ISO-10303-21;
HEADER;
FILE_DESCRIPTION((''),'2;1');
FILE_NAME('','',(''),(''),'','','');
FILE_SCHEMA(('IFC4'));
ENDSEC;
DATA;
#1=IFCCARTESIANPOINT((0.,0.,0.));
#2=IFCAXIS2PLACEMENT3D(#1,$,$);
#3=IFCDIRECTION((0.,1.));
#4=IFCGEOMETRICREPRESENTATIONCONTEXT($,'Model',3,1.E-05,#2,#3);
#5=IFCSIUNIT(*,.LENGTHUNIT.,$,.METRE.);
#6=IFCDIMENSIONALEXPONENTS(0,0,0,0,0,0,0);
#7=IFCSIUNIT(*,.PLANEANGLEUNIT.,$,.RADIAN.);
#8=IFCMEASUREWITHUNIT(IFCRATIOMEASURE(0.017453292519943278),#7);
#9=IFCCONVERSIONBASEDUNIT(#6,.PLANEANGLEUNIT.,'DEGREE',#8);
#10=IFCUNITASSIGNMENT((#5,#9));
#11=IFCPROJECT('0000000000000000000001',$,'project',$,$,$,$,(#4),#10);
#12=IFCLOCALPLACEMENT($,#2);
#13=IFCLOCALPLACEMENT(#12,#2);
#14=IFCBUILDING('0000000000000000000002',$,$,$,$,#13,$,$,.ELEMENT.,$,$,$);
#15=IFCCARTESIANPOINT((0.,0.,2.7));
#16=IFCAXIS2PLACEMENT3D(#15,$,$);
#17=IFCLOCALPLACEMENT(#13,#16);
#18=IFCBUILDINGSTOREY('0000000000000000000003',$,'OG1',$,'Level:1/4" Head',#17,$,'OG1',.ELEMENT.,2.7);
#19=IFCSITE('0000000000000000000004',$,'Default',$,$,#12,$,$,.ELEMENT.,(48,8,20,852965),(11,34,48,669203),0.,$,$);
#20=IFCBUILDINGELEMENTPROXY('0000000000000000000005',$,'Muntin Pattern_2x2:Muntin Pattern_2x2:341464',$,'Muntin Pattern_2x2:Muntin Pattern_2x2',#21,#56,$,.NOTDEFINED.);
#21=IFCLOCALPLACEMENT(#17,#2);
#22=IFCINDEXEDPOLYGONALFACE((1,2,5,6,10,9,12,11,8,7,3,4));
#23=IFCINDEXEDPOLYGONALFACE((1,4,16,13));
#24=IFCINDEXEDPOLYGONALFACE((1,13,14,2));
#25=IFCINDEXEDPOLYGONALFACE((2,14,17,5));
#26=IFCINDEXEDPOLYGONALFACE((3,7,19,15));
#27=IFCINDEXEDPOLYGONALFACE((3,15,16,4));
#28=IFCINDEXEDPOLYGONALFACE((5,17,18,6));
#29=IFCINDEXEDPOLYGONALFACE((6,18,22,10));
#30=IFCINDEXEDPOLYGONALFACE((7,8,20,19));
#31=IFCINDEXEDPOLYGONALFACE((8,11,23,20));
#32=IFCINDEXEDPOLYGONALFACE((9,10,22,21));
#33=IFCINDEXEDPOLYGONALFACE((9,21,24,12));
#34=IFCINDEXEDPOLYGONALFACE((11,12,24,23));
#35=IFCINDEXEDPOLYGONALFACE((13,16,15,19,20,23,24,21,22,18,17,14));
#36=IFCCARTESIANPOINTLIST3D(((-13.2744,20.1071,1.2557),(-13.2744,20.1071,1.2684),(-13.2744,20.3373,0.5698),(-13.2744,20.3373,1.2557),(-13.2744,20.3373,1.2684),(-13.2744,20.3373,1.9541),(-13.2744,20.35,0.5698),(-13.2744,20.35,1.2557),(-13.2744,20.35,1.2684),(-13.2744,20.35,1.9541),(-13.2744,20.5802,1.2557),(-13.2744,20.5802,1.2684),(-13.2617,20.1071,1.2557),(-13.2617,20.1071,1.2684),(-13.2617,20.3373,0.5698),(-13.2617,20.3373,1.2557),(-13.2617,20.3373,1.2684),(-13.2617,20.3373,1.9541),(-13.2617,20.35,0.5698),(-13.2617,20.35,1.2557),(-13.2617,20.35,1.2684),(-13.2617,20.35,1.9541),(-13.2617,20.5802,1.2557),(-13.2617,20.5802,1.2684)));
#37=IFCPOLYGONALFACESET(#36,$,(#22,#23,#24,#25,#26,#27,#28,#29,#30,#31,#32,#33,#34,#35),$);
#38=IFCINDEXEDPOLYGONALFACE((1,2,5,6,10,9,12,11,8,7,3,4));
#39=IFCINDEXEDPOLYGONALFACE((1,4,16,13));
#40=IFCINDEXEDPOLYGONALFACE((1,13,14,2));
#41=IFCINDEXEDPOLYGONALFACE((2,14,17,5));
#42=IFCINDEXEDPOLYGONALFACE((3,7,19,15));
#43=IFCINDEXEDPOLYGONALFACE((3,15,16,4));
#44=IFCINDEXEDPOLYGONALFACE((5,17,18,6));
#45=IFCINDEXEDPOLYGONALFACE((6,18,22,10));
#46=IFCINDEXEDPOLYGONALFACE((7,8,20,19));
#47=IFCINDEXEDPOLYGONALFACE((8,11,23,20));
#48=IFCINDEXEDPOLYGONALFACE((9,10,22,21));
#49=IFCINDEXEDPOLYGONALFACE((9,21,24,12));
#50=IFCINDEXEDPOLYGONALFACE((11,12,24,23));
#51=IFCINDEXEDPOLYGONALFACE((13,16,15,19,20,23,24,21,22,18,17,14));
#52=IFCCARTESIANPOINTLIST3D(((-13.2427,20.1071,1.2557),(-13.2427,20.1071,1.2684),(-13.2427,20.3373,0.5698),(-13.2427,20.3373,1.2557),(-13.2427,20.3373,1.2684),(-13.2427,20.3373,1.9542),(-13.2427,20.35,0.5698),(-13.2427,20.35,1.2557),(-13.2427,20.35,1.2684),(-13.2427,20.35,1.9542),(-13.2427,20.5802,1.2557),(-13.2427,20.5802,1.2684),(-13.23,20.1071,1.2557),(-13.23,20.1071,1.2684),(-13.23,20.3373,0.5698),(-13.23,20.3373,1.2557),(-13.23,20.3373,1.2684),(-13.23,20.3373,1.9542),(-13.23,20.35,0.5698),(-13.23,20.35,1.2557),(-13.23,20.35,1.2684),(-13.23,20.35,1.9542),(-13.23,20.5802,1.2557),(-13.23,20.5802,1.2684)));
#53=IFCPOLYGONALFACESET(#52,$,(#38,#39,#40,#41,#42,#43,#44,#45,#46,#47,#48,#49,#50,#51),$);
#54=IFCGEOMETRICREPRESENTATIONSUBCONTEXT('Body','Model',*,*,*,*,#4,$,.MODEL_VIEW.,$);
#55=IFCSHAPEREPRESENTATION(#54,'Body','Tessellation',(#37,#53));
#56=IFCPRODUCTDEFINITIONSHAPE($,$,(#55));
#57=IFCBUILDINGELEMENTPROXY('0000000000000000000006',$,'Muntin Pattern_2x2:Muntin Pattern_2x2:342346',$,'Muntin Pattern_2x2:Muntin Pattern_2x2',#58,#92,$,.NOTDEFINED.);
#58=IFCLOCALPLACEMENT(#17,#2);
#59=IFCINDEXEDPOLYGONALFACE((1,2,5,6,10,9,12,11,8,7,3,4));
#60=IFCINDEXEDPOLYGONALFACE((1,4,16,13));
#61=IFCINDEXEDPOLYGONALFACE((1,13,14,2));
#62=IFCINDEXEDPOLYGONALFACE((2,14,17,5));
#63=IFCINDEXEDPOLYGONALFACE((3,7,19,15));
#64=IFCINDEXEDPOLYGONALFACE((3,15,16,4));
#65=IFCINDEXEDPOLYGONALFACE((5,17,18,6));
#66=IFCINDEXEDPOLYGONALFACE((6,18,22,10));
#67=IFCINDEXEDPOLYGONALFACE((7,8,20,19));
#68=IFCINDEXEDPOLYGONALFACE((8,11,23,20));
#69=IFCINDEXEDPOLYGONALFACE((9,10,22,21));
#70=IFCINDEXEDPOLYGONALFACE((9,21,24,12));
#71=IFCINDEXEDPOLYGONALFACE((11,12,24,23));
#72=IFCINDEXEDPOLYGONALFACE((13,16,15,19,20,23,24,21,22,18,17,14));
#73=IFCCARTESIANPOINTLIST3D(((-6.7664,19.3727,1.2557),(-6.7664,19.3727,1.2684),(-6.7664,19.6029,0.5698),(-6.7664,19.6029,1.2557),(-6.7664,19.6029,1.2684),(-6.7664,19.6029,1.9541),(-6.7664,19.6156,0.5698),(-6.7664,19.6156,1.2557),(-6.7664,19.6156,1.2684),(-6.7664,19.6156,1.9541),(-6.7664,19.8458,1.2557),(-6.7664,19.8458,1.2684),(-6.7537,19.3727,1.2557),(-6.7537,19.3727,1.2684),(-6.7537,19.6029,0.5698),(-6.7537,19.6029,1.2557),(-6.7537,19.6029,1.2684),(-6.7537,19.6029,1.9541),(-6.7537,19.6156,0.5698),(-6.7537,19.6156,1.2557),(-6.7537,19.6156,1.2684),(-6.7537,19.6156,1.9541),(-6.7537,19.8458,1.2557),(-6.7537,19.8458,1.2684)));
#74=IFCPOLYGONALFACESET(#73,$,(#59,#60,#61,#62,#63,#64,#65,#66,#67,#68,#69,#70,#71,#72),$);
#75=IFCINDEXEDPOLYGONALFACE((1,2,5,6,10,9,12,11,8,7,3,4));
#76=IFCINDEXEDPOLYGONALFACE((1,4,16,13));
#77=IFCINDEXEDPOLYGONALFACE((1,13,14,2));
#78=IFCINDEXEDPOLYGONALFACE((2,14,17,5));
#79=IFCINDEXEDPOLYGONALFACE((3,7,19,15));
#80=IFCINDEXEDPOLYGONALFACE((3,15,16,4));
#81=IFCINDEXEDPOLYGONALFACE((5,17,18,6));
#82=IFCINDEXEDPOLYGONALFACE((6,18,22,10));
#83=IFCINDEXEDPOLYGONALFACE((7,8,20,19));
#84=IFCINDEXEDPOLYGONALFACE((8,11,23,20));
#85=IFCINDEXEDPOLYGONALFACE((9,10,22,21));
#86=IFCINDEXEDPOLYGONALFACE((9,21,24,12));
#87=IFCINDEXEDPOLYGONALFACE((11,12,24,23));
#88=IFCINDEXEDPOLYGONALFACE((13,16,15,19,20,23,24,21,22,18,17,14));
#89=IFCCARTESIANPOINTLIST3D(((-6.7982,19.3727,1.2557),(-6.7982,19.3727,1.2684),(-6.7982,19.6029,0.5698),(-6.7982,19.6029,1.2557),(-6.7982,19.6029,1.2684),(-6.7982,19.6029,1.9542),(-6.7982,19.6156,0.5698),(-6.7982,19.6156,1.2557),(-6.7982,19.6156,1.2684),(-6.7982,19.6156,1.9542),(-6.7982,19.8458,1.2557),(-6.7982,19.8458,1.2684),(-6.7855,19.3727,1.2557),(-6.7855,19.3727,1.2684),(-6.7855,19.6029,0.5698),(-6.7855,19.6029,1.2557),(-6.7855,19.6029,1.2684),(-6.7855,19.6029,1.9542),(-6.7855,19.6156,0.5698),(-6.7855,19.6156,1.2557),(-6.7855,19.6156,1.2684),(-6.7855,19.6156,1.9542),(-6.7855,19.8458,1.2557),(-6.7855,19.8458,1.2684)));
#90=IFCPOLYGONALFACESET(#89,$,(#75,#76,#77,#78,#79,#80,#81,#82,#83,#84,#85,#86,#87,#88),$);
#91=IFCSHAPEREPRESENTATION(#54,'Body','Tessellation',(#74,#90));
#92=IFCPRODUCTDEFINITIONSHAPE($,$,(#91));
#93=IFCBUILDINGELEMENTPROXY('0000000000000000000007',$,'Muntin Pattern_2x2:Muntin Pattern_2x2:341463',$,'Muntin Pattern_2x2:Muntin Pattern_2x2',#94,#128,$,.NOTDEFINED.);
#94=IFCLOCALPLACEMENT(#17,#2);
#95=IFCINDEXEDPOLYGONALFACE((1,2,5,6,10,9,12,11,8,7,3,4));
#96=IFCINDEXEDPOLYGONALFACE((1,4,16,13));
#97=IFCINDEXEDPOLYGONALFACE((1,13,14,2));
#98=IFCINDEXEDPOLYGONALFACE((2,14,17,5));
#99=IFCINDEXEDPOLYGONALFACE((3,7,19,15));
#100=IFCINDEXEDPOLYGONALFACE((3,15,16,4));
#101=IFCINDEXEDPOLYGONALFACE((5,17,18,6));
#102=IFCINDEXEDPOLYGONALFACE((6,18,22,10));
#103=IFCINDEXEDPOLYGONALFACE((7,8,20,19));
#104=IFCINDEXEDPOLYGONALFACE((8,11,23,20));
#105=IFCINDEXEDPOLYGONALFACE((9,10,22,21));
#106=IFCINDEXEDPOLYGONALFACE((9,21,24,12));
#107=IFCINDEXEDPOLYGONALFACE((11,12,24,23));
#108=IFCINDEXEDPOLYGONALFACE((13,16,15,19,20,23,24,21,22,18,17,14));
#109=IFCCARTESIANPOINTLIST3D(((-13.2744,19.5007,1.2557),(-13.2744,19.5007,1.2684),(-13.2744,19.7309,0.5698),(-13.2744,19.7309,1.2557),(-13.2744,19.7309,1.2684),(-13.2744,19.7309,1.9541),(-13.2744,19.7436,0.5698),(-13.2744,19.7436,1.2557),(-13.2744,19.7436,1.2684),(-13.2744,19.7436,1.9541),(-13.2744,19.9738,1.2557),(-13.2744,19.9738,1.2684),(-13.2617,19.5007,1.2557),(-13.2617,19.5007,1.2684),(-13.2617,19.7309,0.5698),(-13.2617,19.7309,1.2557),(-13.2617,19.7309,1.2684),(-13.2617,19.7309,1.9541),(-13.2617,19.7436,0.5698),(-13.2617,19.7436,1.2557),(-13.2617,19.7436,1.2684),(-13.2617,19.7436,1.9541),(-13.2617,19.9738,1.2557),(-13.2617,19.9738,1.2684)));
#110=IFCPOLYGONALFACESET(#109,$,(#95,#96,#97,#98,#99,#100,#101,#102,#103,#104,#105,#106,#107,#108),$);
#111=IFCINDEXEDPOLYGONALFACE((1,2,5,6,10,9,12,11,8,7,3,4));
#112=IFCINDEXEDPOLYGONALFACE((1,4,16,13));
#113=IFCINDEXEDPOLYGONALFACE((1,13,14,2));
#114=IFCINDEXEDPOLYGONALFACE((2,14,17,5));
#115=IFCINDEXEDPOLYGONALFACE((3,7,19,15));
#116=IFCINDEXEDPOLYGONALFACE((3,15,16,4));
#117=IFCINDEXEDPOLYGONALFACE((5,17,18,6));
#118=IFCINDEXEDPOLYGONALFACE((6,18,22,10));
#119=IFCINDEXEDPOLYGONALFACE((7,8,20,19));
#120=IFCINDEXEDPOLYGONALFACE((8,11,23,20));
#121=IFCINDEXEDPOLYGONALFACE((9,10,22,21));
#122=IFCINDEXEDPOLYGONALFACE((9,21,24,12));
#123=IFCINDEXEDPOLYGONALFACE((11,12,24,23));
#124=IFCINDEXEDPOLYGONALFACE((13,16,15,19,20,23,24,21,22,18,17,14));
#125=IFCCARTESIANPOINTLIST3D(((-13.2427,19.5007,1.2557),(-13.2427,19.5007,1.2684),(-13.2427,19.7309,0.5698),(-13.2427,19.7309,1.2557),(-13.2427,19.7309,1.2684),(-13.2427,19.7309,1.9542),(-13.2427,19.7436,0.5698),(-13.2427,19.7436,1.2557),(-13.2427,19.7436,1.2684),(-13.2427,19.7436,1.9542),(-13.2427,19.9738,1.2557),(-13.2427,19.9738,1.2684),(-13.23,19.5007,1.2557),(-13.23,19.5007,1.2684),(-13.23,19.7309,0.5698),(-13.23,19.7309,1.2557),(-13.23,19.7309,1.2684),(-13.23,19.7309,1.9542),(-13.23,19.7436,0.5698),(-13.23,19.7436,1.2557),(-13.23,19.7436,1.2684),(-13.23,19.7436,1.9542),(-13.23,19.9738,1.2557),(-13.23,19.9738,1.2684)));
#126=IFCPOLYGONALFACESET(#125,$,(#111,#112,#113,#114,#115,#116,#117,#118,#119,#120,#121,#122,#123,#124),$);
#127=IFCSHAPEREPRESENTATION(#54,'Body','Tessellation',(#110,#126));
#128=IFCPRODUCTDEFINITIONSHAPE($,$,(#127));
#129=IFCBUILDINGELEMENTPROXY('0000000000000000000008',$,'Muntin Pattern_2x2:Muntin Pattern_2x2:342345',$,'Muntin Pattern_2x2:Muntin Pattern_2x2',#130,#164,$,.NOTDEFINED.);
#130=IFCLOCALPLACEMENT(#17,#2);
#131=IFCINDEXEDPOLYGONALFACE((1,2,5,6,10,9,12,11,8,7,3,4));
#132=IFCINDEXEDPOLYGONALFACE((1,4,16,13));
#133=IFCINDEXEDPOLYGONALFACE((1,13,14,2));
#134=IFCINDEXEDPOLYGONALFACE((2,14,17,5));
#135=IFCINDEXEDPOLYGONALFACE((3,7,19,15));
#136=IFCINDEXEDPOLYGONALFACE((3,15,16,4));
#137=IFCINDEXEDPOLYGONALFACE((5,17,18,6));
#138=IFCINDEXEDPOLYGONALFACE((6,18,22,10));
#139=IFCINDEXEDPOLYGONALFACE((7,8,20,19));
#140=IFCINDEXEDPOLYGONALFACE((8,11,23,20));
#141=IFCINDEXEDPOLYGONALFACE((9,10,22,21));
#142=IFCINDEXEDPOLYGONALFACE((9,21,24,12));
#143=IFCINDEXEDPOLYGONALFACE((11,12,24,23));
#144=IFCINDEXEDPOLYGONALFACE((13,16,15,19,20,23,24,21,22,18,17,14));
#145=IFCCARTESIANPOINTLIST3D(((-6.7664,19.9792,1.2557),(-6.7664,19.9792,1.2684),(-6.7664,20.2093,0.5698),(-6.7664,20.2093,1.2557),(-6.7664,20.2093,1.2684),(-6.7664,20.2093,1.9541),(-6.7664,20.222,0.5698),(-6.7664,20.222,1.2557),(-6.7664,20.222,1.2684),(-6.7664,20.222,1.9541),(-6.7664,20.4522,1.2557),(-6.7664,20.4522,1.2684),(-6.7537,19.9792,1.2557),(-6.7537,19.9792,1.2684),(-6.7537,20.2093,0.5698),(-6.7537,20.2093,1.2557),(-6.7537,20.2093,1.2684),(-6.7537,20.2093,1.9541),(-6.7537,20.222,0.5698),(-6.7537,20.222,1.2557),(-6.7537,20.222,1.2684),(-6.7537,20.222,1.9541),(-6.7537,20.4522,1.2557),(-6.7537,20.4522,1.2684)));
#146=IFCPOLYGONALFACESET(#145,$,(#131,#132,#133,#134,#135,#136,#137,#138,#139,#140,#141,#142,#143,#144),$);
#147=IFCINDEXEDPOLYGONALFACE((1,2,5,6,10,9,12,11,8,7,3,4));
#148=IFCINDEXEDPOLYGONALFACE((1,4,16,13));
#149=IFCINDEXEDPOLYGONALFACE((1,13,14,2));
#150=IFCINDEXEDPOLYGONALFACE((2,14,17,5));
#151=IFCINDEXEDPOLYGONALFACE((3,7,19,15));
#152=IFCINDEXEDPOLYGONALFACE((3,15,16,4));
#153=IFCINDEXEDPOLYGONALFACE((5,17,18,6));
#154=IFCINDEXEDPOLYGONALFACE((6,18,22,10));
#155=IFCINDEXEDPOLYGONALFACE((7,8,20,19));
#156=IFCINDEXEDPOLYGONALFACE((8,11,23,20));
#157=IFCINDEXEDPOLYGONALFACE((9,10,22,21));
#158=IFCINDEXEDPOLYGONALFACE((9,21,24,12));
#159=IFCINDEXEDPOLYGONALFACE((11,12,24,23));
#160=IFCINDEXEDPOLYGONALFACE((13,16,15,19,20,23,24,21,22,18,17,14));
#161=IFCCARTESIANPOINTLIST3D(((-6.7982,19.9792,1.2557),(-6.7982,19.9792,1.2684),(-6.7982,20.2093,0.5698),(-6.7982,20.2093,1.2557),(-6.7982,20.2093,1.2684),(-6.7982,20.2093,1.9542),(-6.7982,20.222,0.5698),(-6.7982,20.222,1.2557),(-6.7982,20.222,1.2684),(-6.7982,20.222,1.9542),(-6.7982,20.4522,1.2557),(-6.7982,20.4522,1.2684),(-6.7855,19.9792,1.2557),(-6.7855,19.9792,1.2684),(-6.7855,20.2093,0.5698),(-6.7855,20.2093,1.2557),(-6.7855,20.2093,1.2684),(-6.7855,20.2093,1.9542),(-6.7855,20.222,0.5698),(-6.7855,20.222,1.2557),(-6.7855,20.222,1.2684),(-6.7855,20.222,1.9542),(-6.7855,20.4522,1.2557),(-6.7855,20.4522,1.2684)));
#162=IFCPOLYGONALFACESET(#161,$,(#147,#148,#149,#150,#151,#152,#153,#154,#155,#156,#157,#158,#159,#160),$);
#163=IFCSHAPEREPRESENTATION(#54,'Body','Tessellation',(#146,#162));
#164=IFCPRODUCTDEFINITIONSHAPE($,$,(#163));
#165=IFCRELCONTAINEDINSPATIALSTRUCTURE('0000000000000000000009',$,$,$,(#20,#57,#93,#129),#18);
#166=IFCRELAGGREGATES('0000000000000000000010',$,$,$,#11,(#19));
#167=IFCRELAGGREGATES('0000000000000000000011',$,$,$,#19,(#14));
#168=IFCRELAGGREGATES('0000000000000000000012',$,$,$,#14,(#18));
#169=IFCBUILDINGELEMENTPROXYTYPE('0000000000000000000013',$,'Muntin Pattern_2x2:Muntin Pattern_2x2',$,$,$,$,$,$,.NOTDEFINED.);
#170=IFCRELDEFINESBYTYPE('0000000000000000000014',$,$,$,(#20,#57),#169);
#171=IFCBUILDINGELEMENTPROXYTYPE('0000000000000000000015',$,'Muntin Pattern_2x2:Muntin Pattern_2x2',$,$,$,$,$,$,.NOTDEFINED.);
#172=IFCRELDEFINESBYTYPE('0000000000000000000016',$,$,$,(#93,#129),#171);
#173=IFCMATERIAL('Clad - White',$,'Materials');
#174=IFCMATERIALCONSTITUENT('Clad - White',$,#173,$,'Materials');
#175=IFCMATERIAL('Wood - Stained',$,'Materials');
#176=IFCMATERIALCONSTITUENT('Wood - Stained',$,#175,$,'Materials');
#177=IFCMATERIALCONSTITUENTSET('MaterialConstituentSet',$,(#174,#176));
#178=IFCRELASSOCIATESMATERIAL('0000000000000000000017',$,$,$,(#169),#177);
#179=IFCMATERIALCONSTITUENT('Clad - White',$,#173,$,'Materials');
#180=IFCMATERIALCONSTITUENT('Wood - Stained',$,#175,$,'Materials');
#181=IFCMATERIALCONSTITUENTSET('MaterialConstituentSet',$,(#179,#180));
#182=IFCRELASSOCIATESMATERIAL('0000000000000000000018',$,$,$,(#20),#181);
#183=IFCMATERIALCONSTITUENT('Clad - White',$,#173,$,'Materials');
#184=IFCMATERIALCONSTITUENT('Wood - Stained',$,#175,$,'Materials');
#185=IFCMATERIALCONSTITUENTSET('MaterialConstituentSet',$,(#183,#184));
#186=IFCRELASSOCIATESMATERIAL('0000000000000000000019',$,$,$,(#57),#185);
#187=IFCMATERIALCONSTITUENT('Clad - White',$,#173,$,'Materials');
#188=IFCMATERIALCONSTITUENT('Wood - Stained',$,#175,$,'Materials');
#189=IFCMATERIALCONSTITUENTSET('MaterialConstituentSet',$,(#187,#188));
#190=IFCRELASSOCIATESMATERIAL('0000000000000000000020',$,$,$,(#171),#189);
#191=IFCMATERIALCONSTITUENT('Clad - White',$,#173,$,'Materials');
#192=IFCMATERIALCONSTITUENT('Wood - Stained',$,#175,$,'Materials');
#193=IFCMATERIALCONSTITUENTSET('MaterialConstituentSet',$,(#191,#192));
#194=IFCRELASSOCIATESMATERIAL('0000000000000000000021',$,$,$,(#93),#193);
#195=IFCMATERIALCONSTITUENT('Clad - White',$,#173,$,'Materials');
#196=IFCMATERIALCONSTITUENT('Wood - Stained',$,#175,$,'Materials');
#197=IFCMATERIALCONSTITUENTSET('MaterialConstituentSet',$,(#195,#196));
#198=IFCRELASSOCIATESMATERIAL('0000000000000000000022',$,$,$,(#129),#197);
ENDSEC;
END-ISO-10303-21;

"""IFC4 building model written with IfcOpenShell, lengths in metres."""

from ifc_helpers import new_model, entity, si_unit, converted_unit, direction, frame, origin, place, context, subcontext, project, spatial, indexed_curve, outline, extrude, source, transform, mapped, material, constituent, constituent_set, type_object, type_shapes, element, save


model = new_model("IFC4")

# Units and contexts
model_context = context("Model", 3, precision=1e-05, world=origin(), true_north=direction((0.0, 1.0)))
body_context = subcontext(model_context, "Body", "Model", "MODEL_VIEW")
ifc_project = project(units=[si_unit("LENGTHUNIT", "METRE"), converted_unit("PLANEANGLEUNIT", "DEGREE", entity("IfcRatioMeasure", 0.017453292519943278), si_unit("PLANEANGLEUNIT", "RADIAN"), dimensions=[0, 0, 0, 0, 0, 0, 0])], contexts=[model_context])

# Site, building, storey
site_placement = place(None, origin())
site = spatial("IfcSite", under=ifc_project, at=site_placement, Name="Default", CompositionType="ELEMENT", RefLatitude=(48, 8, 20, 852965), RefLongitude=(11, 34, 48, 669203), RefElevation=0.0)
building_placement = place(site_placement, origin())
building = spatial("IfcBuilding", under=site, at=building_placement, CompositionType="ELEMENT")
storey_placement = place(building_placement, frame((0.0, 0.0, 2.7)))
storey = spatial("IfcBuildingStorey", under=building, at=storey_placement, Name="OG1", ObjectType="Level:1/4\" Head", LongName="OG1", CompositionType="ELEMENT", Elevation=2.7)

# Building element proxies
ifc_material_1 = material(Name="Clad - White", Category="Materials")
ifc_material_2 = material(Name="Wood - Stained", Category="Materials")
ifc_constituent_1 = constituent(ifc_material_1, Name="Clad - White", Category="Materials")
ifc_constituent_2 = constituent(ifc_material_2, Name="Wood - Stained", Category="Materials")
ifc_constituent_set_1 = constituent_set(constituents=[ifc_constituent_1, ifc_constituent_2], Name="MaterialConstituentSet")
building_element_proxy_type_1 = type_object("IfcBuildingElementProxyType", Name="Muntin Pattern_2x2:Muntin Pattern_2x2", PredefinedType="NOTDEFINED", material=ifc_constituent_set_1)
shared_shape_1 = source(origin(), body_context, "Body", "SweptSolid", [
    extrude(outline(indexed_curve([(0.0064, -0.0064), (0.6921, -0.0064), (0.6921, 0.0063), (0.0064, 0.0063), (0.0064, 0.2365), (-0.0063, 0.2365), (-0.0063, 0.0063), (-0.6922, 0.0063), (-0.6922, -0.0064), (-0.0063, -0.0064), (-0.0063, -0.2365), (0.0064, -0.2365), (0.0064, -0.0064)], self_intersect=False)), frame((0.0, -0.0222, 0.6921), z_axis=(0.0, 1.0, 0.0), x_axis=(0.0, 0.0, 1.0)), (0.0, 0.0, 1.0), 0.0127),
    extrude(outline(indexed_curve([(0.0064, -0.0064), (0.6922, -0.0064), (0.6922, 0.0063), (0.0064, 0.0063), (0.0064, 0.2365), (-0.0063, 0.2365), (-0.0063, 0.0063), (-0.6922, 0.0063), (-0.6922, -0.0064), (-0.0063, -0.0064), (-0.0063, -0.2365), (0.0064, -0.2365), (0.0064, -0.0064)], self_intersect=False)), frame((0.0, 0.0095, 0.6922), z_axis=(0.0, 1.0, 0.0), x_axis=(0.0, 0.0, 1.0)), (0.0, 0.0, 1.0), 0.0127),
])
type_shapes(building_element_proxy_type_1, [shared_shape_1])
ifc_constituent_3 = constituent(ifc_material_1, Name="Clad - White", Category="Materials")
ifc_constituent_4 = constituent(ifc_material_2, Name="Wood - Stained", Category="Materials")
ifc_constituent_set_2 = constituent_set(constituents=[ifc_constituent_3, ifc_constituent_4], Name="MaterialConstituentSet")
proxy_1_placement = place(storey_placement, frame((-13.2522, 20.3437, 0.5699), z_axis=(0.0, 0.0, 1.0), x_axis=(0.0, -1.0, 0.0)))
element("IfcBuildingElementProxy", 1, at=proxy_1_placement, inside=storey, type_object=building_element_proxy_type_1, material=ifc_constituent_set_2, Name="Muntin Pattern_2x2:Muntin Pattern_2x2:341464", ObjectType="Muntin Pattern_2x2:Muntin Pattern_2x2", PredefinedType="NOTDEFINED", context=body_context, shape_type="MappedRepresentation", body=[
    mapped(shared_shape_1, transform((0.0, 0.0, 0.0), scale=1.0)),
])
ifc_constituent_5 = constituent(ifc_material_1, Name="Clad - White", Category="Materials")
ifc_constituent_6 = constituent(ifc_material_2, Name="Wood - Stained", Category="Materials")
ifc_constituent_set_3 = constituent_set(constituents=[ifc_constituent_5, ifc_constituent_6], Name="MaterialConstituentSet")
proxy_2_placement = place(storey_placement, frame((-6.7759, 19.6093, 0.5699), z_axis=(0.0, 0.0, 1.0), x_axis=(0.0, 1.0, 0.0)))
element("IfcBuildingElementProxy", 2, at=proxy_2_placement, inside=storey, type_object=building_element_proxy_type_1, material=ifc_constituent_set_3, Name="Muntin Pattern_2x2:Muntin Pattern_2x2:342346", ObjectType="Muntin Pattern_2x2:Muntin Pattern_2x2", PredefinedType="NOTDEFINED", context=body_context, shape_type="MappedRepresentation", body=[
    mapped(shared_shape_1, transform((0.0, 0.0, 0.0), scale=1.0)),
])
ifc_constituent_7 = constituent(ifc_material_1, Name="Clad - White", Category="Materials")
ifc_constituent_8 = constituent(ifc_material_2, Name="Wood - Stained", Category="Materials")
ifc_constituent_set_4 = constituent_set(constituents=[ifc_constituent_7, ifc_constituent_8], Name="MaterialConstituentSet")
ifc_constituent_9 = constituent(ifc_material_1, Name="Clad - White", Category="Materials")
ifc_constituent_10 = constituent(ifc_material_2, Name="Wood - Stained", Category="Materials")
ifc_constituent_set_5 = constituent_set(constituents=[ifc_constituent_9, ifc_constituent_10], Name="MaterialConstituentSet")
building_element_proxy_type_2 = type_object("IfcBuildingElementProxyType", Name="Muntin Pattern_2x2:Muntin Pattern_2x2", PredefinedType="NOTDEFINED", material=ifc_constituent_set_5)
shared_shape_2 = source(origin(), body_context, "Body", "SweptSolid", [
    extrude(outline(indexed_curve([(0.0064, -0.0064), (0.6921, -0.0064), (0.6921, 0.0063), (0.0064, 0.0063), (0.0064, 0.2365), (-0.0063, 0.2365), (-0.0063, 0.0063), (-0.6922, 0.0063), (-0.6922, -0.0064), (-0.0063, -0.0064), (-0.0063, -0.2365), (0.0064, -0.2365), (0.0064, -0.0064)], self_intersect=False)), frame((0.0, 0.0095, 0.6921), z_axis=(0.0, 1.0, 0.0), x_axis=(0.0, 0.0, 1.0)), (0.0, 0.0, 1.0), 0.0127),
    extrude(outline(indexed_curve([(0.0064, -0.0064), (0.6922, -0.0064), (0.6922, 0.0063), (0.0064, 0.0063), (0.0064, 0.2365), (-0.0063, 0.2365), (-0.0063, 0.0063), (-0.6922, 0.0063), (-0.6922, -0.0064), (-0.0063, -0.0064), (-0.0063, -0.2365), (0.0064, -0.2365), (0.0064, -0.0064)], self_intersect=False)), frame((0.0, -0.0222, 0.6922), z_axis=(0.0, 1.0, 0.0), x_axis=(0.0, 0.0, 1.0)), (0.0, 0.0, 1.0), 0.0127),
])
type_shapes(building_element_proxy_type_2, [shared_shape_2])
proxy_3_placement = place(storey_placement, frame((-13.2522, 19.7372, 0.5699), z_axis=(0.0, 0.0, 1.0), x_axis=(0.0, 1.0, 0.0)))
element("IfcBuildingElementProxy", 3, at=proxy_3_placement, inside=storey, type_object=building_element_proxy_type_2, material=ifc_constituent_set_4, Name="Muntin Pattern_2x2:Muntin Pattern_2x2:341463", ObjectType="Muntin Pattern_2x2:Muntin Pattern_2x2", PredefinedType="NOTDEFINED", context=body_context, shape_type="MappedRepresentation", body=[
    mapped(shared_shape_2, transform((0.0, 0.0, 0.0), scale=1.0)),
])
ifc_constituent_11 = constituent(ifc_material_1, Name="Clad - White", Category="Materials")
ifc_constituent_12 = constituent(ifc_material_2, Name="Wood - Stained", Category="Materials")
ifc_constituent_set_6 = constituent_set(constituents=[ifc_constituent_11, ifc_constituent_12], Name="MaterialConstituentSet")
proxy_4_placement = place(storey_placement, frame((-6.7759, 20.2157, 0.5699), z_axis=(0.0, 0.0, 1.0), x_axis=(0.0, -1.0, 0.0)))
element("IfcBuildingElementProxy", 4, at=proxy_4_placement, inside=storey, type_object=building_element_proxy_type_2, material=ifc_constituent_set_6, Name="Muntin Pattern_2x2:Muntin Pattern_2x2:342345", ObjectType="Muntin Pattern_2x2:Muntin Pattern_2x2", PredefinedType="NOTDEFINED", context=body_context, shape_type="MappedRepresentation", body=[
    mapped(shared_shape_2, transform((0.0, 0.0, 0.0), scale=1.0)),
])

save(model, "model.ifc")
